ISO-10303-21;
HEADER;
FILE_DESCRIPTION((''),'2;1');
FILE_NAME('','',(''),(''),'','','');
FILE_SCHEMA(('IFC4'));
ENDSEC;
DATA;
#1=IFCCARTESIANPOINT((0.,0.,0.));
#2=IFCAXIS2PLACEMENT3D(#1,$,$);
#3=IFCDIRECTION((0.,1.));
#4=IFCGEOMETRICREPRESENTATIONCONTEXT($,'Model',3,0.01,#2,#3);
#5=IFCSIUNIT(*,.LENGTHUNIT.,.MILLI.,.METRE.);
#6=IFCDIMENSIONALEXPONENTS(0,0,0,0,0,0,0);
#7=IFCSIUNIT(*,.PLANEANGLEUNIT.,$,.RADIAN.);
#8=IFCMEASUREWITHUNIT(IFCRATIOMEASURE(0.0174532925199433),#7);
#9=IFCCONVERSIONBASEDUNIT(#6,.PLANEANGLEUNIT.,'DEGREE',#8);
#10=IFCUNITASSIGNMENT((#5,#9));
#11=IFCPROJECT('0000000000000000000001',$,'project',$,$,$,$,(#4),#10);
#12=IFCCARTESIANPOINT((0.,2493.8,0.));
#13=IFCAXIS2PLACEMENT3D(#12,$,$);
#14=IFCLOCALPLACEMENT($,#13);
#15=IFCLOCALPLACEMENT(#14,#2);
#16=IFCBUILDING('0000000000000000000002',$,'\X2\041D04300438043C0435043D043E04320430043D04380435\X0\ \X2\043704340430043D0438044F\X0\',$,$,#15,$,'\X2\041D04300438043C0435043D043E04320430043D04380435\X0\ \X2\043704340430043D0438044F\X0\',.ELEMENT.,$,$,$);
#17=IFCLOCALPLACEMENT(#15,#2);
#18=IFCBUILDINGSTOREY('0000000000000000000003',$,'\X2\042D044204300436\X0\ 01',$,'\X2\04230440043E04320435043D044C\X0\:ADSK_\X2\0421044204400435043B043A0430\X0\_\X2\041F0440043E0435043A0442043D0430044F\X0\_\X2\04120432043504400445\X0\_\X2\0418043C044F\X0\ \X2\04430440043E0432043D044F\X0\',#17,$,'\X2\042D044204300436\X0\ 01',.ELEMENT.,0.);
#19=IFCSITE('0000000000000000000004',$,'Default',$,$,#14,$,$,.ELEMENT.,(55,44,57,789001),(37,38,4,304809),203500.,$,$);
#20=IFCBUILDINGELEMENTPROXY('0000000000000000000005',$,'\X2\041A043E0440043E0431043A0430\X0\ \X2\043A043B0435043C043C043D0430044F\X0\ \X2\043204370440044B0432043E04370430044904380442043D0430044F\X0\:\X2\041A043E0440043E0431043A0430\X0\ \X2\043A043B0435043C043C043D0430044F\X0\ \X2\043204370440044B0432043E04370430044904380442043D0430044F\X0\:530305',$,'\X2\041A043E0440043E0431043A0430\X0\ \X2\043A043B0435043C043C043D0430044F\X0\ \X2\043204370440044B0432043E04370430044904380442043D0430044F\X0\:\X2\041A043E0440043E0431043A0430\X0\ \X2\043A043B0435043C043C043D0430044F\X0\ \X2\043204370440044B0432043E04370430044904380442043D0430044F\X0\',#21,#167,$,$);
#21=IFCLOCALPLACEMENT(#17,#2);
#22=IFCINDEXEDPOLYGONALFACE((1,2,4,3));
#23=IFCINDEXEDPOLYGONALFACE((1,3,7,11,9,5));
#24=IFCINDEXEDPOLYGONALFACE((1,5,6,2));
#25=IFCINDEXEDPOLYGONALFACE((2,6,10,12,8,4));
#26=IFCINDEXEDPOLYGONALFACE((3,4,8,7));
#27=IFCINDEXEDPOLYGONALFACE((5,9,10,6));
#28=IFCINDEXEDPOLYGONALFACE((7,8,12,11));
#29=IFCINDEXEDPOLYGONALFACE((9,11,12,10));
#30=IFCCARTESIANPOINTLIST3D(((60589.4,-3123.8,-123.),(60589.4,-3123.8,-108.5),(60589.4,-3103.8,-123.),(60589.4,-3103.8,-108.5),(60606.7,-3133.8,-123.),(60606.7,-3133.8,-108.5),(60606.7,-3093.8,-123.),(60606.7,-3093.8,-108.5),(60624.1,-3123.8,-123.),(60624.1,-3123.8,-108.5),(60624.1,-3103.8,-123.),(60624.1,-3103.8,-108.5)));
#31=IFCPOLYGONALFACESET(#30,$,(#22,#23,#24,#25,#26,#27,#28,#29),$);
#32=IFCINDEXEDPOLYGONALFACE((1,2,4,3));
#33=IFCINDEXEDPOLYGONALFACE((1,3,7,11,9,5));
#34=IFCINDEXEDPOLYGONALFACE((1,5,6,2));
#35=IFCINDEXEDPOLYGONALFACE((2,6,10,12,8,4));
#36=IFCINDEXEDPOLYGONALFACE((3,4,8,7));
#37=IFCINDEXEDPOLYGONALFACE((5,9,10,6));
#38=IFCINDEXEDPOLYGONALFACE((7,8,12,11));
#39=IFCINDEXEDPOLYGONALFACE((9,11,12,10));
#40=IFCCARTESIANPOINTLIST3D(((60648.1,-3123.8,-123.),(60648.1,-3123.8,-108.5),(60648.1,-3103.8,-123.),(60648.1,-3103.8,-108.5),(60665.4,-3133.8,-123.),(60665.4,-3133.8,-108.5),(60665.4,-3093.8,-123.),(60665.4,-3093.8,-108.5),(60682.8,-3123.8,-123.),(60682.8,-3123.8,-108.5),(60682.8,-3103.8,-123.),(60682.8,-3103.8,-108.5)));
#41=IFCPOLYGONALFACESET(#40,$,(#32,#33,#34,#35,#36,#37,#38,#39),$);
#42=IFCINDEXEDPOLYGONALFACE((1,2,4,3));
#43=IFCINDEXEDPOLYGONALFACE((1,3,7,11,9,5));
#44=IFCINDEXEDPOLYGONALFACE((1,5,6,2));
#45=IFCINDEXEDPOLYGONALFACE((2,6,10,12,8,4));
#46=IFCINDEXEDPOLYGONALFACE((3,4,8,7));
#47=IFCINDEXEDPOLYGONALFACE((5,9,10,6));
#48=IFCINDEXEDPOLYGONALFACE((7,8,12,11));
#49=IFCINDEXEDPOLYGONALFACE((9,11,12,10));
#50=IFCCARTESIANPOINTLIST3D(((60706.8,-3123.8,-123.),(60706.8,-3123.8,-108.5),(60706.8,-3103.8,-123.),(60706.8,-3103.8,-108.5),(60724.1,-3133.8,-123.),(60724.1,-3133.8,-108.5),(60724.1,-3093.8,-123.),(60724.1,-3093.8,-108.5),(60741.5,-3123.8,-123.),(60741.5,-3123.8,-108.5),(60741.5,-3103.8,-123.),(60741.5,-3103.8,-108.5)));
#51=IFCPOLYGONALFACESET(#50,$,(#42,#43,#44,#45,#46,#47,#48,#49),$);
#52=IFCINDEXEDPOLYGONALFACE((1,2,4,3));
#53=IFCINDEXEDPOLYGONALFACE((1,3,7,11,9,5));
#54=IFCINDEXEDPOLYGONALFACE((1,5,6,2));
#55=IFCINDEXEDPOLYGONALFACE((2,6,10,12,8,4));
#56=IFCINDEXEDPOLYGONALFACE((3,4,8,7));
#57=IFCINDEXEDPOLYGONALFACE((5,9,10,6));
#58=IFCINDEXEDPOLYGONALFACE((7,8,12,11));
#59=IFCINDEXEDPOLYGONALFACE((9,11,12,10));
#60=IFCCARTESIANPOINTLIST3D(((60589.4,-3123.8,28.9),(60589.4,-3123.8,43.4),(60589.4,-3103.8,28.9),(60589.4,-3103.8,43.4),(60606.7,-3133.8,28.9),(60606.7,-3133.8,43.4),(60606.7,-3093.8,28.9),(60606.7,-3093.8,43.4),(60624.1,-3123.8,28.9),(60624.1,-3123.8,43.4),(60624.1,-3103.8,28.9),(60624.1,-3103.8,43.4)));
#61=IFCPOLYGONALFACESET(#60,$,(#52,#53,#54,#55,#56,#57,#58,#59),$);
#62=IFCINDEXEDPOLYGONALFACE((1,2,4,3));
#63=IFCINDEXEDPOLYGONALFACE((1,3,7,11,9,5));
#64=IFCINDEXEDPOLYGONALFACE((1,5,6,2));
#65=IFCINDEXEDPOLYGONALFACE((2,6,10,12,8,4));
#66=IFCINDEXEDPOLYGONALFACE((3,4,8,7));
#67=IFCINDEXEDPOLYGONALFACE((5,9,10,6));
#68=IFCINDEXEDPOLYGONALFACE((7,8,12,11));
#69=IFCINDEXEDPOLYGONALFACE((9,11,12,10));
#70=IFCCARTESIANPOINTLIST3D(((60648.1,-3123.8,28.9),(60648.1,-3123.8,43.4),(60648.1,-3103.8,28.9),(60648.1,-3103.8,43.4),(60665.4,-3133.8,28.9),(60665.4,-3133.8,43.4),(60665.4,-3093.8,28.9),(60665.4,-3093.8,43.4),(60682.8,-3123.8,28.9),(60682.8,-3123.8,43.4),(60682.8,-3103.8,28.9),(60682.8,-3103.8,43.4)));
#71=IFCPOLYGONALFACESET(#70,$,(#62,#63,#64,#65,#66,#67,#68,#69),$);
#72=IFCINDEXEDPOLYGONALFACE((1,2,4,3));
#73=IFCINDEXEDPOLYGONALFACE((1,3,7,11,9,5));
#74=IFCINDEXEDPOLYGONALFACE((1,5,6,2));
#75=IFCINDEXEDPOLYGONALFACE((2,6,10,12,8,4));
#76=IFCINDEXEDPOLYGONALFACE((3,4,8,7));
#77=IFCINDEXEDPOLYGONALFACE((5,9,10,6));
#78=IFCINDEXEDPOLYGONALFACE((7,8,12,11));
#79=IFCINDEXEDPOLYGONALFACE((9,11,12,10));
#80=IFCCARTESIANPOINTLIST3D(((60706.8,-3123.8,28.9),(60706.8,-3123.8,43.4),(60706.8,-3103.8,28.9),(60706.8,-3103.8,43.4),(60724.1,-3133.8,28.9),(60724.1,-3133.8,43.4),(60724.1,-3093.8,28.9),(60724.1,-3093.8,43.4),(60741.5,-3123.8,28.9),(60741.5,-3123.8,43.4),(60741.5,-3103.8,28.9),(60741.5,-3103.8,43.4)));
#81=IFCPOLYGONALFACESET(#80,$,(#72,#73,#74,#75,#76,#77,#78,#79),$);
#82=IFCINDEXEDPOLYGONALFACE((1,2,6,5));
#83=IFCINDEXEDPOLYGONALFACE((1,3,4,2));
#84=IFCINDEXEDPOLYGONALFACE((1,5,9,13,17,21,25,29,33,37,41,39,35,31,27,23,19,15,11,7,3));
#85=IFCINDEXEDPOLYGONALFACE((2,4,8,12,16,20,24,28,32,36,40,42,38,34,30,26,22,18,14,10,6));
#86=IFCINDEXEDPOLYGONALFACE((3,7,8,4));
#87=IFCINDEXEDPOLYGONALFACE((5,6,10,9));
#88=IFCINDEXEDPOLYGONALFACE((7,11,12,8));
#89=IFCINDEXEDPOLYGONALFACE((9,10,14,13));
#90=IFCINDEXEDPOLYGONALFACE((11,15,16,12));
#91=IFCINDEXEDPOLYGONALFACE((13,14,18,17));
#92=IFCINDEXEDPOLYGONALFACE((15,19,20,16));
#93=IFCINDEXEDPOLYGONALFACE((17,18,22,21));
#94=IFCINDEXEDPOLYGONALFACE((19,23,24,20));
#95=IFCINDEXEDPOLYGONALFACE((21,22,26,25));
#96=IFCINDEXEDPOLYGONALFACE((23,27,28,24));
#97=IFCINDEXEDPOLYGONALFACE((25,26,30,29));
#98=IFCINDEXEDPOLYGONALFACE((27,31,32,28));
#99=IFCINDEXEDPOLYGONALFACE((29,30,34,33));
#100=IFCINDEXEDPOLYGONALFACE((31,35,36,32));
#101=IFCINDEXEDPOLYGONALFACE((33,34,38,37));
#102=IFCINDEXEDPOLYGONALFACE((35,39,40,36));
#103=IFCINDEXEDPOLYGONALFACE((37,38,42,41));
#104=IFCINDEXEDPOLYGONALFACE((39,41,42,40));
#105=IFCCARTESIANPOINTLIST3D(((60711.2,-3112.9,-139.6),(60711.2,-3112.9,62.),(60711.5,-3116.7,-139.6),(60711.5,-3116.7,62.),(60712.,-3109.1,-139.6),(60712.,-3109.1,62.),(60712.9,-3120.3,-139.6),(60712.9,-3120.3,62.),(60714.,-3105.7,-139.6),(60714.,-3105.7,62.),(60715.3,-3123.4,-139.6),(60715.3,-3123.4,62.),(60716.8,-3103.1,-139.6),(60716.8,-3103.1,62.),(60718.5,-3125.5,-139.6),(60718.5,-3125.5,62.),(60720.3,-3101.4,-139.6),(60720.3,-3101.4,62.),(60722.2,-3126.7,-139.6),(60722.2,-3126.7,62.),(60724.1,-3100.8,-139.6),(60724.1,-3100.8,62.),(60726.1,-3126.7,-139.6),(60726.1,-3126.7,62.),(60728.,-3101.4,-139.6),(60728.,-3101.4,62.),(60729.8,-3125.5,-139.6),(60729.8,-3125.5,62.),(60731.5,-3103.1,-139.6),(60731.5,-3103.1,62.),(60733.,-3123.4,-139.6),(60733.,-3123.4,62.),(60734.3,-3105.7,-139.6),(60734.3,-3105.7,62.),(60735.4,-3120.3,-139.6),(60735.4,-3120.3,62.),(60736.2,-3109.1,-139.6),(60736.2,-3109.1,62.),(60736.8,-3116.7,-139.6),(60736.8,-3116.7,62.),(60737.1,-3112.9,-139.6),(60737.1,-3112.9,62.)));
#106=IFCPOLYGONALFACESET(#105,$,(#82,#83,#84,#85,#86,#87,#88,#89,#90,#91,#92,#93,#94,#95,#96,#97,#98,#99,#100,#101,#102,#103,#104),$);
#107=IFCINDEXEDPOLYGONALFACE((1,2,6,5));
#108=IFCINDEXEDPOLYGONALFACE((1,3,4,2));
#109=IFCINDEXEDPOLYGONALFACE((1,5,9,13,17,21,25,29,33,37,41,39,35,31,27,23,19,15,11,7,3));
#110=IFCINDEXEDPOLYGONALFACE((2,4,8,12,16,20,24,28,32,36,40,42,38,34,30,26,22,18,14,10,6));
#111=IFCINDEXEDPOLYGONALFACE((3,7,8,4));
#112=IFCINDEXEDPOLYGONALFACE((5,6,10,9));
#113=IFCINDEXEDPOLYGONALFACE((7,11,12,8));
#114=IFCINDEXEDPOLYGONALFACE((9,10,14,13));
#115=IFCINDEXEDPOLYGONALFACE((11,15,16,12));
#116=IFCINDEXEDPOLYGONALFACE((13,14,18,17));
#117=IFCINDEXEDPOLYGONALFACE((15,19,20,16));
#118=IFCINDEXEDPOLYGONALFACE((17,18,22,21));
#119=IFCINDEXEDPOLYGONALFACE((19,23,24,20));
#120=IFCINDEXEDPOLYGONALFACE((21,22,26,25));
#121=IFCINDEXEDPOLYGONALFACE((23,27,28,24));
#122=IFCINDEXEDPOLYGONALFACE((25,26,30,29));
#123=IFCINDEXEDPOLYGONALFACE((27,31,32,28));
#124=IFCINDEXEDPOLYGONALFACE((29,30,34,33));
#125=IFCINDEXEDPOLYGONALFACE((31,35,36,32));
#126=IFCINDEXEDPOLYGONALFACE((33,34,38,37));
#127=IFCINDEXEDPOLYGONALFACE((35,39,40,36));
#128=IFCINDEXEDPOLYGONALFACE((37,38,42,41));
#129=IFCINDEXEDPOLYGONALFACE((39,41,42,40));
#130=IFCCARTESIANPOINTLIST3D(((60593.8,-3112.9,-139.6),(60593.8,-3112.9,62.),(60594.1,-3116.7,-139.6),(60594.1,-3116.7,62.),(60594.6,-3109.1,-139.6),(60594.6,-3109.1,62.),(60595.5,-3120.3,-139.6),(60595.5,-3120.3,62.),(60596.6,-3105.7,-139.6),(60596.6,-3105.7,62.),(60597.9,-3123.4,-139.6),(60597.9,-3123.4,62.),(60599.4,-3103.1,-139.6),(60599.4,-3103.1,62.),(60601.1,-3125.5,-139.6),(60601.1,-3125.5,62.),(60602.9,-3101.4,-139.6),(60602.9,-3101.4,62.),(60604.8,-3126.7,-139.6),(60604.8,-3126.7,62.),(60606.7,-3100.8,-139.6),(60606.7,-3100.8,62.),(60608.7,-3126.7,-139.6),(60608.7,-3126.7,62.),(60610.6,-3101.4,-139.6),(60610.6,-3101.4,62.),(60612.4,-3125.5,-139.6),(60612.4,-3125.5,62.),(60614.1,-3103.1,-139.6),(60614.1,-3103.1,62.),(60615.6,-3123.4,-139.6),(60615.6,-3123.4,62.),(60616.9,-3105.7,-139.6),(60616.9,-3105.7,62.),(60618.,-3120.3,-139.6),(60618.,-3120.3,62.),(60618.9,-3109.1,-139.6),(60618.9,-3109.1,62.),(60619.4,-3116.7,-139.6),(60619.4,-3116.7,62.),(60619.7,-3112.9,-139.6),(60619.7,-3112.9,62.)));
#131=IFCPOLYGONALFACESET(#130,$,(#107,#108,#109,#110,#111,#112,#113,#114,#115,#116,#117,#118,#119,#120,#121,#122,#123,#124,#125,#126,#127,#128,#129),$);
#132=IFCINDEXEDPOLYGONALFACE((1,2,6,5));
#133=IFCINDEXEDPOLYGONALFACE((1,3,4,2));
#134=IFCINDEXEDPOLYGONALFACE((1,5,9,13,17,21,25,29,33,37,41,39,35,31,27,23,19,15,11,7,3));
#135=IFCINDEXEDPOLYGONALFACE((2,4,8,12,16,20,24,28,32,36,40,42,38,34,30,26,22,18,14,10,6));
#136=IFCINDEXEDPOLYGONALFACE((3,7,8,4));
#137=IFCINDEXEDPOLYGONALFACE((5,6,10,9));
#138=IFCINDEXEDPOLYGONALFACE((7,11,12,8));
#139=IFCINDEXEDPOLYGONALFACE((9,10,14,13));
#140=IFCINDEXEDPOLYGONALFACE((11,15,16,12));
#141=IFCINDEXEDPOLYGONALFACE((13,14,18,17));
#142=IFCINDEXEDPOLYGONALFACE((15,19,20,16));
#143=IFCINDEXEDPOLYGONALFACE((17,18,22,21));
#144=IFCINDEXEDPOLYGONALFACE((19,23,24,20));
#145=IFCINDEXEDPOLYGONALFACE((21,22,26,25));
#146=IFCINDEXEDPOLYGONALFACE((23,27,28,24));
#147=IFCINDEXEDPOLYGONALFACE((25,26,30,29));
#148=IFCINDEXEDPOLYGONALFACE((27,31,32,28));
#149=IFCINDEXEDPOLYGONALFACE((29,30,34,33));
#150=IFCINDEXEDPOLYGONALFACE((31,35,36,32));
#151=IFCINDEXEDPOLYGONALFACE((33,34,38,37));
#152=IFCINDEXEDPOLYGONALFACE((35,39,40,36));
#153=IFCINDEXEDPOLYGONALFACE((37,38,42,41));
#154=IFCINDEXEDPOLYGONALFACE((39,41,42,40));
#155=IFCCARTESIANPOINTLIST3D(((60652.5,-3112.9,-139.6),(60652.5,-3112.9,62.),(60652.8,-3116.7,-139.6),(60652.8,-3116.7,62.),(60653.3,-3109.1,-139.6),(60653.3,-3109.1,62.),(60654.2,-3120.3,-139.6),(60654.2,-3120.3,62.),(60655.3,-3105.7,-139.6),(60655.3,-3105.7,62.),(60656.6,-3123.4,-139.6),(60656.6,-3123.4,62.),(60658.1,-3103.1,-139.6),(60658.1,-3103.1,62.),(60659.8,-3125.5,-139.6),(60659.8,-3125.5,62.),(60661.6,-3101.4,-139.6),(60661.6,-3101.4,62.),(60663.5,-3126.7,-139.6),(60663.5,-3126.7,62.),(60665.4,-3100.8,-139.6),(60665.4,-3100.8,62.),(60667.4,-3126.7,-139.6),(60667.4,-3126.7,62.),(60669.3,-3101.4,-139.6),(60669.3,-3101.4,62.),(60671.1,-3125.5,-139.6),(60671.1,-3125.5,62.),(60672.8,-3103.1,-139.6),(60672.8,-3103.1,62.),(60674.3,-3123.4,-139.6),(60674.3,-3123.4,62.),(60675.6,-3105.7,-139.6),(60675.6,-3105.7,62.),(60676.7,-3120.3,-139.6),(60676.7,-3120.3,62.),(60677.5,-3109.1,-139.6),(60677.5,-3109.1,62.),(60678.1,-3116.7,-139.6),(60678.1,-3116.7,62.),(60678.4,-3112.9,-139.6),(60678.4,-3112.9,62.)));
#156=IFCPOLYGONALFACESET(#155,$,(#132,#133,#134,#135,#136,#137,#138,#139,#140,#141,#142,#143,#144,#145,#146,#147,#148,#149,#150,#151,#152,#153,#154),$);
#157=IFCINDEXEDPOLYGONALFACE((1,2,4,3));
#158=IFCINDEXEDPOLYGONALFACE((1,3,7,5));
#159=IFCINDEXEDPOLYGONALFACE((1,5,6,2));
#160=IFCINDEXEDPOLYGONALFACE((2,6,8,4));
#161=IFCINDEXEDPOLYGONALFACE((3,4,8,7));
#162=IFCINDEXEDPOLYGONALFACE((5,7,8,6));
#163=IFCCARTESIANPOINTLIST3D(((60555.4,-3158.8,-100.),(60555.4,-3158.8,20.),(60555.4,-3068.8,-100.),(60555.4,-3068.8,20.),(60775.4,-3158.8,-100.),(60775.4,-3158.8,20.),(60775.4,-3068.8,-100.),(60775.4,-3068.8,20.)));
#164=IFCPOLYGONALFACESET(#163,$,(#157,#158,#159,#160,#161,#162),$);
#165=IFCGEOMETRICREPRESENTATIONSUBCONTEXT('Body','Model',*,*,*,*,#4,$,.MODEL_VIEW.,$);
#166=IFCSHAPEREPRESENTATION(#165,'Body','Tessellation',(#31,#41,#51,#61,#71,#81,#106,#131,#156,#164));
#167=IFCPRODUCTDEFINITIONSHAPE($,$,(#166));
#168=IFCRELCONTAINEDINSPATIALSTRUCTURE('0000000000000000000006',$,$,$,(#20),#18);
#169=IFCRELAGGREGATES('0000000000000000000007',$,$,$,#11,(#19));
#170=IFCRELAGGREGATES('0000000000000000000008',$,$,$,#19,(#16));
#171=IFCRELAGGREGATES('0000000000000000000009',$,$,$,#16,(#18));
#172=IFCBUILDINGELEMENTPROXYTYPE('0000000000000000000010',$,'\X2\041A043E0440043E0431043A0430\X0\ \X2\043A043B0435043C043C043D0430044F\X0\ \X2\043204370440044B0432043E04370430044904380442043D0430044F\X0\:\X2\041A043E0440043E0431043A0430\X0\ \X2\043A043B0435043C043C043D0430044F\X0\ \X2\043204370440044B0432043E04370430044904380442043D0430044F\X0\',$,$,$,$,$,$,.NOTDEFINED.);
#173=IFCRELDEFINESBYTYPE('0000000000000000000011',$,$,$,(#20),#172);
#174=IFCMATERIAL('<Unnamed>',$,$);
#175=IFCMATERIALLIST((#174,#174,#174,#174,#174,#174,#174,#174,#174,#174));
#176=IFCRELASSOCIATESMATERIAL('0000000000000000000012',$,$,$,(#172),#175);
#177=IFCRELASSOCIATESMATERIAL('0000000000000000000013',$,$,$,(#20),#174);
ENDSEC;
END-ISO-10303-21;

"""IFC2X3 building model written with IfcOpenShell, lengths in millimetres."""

from ifc_helpers import new_model, entity, si_unit, converted_unit, direction, frame, frame_2d, origin, place, context, subcontext, project, spatial, polyline, rectangle, circle, outline, extrude, source, transform, mapped, material, material_list, type_object, type_shapes, element, save


model = new_model("IFC2X3")

# Units and contexts
model_context = context("Model", 3, precision=0.01, world=origin(), true_north=direction((0.0, 1.0)))
body_context = subcontext(model_context, "Body", "Model", "MODEL_VIEW")
ifc_project = project(units=[si_unit("LENGTHUNIT", "METRE", prefix="MILLI"), converted_unit("PLANEANGLEUNIT", "DEGREE", entity("IfcRatioMeasure", 0.0174532925199433), si_unit("PLANEANGLEUNIT", "RADIAN"), dimensions=[0, 0, 0, 0, 0, 0, 0])], contexts=[model_context])

# Site, building, storey
site_placement = place(None, frame((0.0, 2493.8, 0.0)))
site = spatial("IfcSite", under=ifc_project, at=site_placement, Name="Default", CompositionType="ELEMENT", RefLatitude=(55, 44, 57, 789001), RefLongitude=(37, 38, 4, 304809), RefElevation=203500.0)
building_placement = place(site_placement, origin())
building = spatial("IfcBuilding", under=site, at=building_placement, Name="Наименование здания", LongName="Наименование здания", CompositionType="ELEMENT")
storey_placement = place(building_placement, origin())
storey = spatial("IfcBuildingStorey", under=building, at=storey_placement, Name="Этаж 01", ObjectType="Уровень:ADSK_Стрелка_Проектная_Вверх_Имя уровня", LongName="Этаж 01", CompositionType="ELEMENT", Elevation=0.0)

# Building element proxy
ifc_material_1 = material(Name="<Unnamed>")
ifc_material_list_1 = material_list([ifc_material_1, ifc_material_1, ifc_material_1, ifc_material_1, ifc_material_1, ifc_material_1, ifc_material_1, ifc_material_1, ifc_material_1, ifc_material_1])
building_element_proxy_type_1 = type_object("IfcBuildingElementProxyType", Name="Коробка клеммная взрывозащитная:Коробка клеммная взрывозащитная", PredefinedType="NOTDEFINED", material=ifc_material_list_1)
shared_shape_1 = source(origin(), body_context, "Body", "SweptSolid", [
    extrude(outline(polyline([(-10.0, -17.3), (10.0, -17.3), (20.0, 0.0), (10.0, 17.3), (-10.0, 17.3), (-20.0, 0.0), (-10.0, -17.3)])), frame((0.0, 58.7, -23.0), z_axis=(0.0, 0.0, 1.0), x_axis=(-1.0, 0.0, 0.0)), (0.0, 0.0, 1.0), 14.4),
    extrude(outline(polyline([(-10.0, -17.3), (10.0, -17.3), (20.0, 0.0), (10.0, 17.3), (-10.0, 17.3), (-20.0, 0.0), (-10.0, -17.3)])), frame((0.0, 0.0, -23.0), z_axis=(0.0, 0.0, 1.0), x_axis=(-1.0, 0.0, 0.0)), (0.0, 0.0, 1.0), 14.4),
    extrude(outline(polyline([(-10.0, -17.3), (10.0, -17.3), (20.0, 0.0), (10.0, 17.3), (-10.0, 17.3), (-20.0, 0.0), (-10.0, -17.3)])), frame((0.0, -58.7, -23.0), z_axis=(0.0, 0.0, 1.0), x_axis=(-1.0, 0.0, 0.0)), (0.0, 0.0, 1.0), 14.4),
    extrude(outline(polyline([(-10.0, -17.3), (10.0, -17.3), (20.0, 0.0), (10.0, 17.3), (-10.0, 17.3), (-20.0, 0.0), (-10.0, -17.3)])), frame((0.0, 58.7, 128.9), z_axis=(0.0, 0.0, 1.0), x_axis=(-1.0, 0.0, 0.0)), (0.0, 0.0, 1.0), 14.4),
    extrude(outline(polyline([(-10.0, -17.3), (10.0, -17.3), (20.0, 0.0), (10.0, 17.3), (-10.0, 17.3), (-20.0, 0.0), (-10.0, -17.3)])), frame((0.0, 0.0, 128.9), z_axis=(0.0, 0.0, 1.0), x_axis=(-1.0, 0.0, 0.0)), (0.0, 0.0, 1.0), 14.4),
    extrude(outline(polyline([(-10.0, -17.3), (10.0, -17.3), (20.0, 0.0), (10.0, 17.3), (-10.0, 17.3), (-20.0, 0.0), (-10.0, -17.3)])), frame((0.0, -58.7, 128.9), z_axis=(0.0, 0.0, 1.0), x_axis=(-1.0, 0.0, 0.0)), (0.0, 0.0, 1.0), 14.4),
    extrude(circle(Radius=13.0, at=frame_2d((0.0, 0.0), x_axis=(1.0, 0.0))), frame((0.0, -58.7, -39.6)), (0.0, 0.0, 1.0), 201.6),
    extrude(circle(Radius=13.0, at=frame_2d((0.0, 0.0), x_axis=(1.0, 0.0))), frame((0.0, 58.7, -39.6)), (0.0, 0.0, 1.0), 201.6),
    extrude(circle(Radius=13.0, at=frame_2d((0.0, 0.0), x_axis=(1.0, 0.0))), frame((0.0, 0.0, -39.6)), (0.0, 0.0, 1.0), 201.6),
    extrude(rectangle(XDim=220.0, YDim=90.0, at=frame_2d((0.0, 0.0), x_axis=(1.0, 0.0))), frame((0.0, 0.0, 0.0), z_axis=(0.0, 0.0, 1.0), x_axis=(0.0, -1.0, 0.0)), (0.0, 0.0, 1.0), 120.0),
])
type_shapes(building_element_proxy_type_1, [shared_shape_1])
for number, where, z_axis, x_axis, name in (
    (1, (60665.4, -3113.8, -100.0), (0.0, 0.0, 1.0), (0.0, 1.0, 0.0), "Коробка клеммная взрывозащитная:Коробка клеммная взрывозащитная:530305"),
):
    element("IfcBuildingElementProxy", number, at=place(storey_placement, frame(where, z_axis=z_axis, x_axis=x_axis)), inside=storey, type_object=building_element_proxy_type_1, material=ifc_material_1, Name=name, ObjectType="Коробка клеммная взрывозащитная:Коробка клеммная взрывозащитная", context=body_context, shape_type="MappedRepresentation", body=[
        mapped(shared_shape_1, transform((0.0, 0.0, 0.0), scale=1.0)),
    ])

save(model, "model.ifc")
